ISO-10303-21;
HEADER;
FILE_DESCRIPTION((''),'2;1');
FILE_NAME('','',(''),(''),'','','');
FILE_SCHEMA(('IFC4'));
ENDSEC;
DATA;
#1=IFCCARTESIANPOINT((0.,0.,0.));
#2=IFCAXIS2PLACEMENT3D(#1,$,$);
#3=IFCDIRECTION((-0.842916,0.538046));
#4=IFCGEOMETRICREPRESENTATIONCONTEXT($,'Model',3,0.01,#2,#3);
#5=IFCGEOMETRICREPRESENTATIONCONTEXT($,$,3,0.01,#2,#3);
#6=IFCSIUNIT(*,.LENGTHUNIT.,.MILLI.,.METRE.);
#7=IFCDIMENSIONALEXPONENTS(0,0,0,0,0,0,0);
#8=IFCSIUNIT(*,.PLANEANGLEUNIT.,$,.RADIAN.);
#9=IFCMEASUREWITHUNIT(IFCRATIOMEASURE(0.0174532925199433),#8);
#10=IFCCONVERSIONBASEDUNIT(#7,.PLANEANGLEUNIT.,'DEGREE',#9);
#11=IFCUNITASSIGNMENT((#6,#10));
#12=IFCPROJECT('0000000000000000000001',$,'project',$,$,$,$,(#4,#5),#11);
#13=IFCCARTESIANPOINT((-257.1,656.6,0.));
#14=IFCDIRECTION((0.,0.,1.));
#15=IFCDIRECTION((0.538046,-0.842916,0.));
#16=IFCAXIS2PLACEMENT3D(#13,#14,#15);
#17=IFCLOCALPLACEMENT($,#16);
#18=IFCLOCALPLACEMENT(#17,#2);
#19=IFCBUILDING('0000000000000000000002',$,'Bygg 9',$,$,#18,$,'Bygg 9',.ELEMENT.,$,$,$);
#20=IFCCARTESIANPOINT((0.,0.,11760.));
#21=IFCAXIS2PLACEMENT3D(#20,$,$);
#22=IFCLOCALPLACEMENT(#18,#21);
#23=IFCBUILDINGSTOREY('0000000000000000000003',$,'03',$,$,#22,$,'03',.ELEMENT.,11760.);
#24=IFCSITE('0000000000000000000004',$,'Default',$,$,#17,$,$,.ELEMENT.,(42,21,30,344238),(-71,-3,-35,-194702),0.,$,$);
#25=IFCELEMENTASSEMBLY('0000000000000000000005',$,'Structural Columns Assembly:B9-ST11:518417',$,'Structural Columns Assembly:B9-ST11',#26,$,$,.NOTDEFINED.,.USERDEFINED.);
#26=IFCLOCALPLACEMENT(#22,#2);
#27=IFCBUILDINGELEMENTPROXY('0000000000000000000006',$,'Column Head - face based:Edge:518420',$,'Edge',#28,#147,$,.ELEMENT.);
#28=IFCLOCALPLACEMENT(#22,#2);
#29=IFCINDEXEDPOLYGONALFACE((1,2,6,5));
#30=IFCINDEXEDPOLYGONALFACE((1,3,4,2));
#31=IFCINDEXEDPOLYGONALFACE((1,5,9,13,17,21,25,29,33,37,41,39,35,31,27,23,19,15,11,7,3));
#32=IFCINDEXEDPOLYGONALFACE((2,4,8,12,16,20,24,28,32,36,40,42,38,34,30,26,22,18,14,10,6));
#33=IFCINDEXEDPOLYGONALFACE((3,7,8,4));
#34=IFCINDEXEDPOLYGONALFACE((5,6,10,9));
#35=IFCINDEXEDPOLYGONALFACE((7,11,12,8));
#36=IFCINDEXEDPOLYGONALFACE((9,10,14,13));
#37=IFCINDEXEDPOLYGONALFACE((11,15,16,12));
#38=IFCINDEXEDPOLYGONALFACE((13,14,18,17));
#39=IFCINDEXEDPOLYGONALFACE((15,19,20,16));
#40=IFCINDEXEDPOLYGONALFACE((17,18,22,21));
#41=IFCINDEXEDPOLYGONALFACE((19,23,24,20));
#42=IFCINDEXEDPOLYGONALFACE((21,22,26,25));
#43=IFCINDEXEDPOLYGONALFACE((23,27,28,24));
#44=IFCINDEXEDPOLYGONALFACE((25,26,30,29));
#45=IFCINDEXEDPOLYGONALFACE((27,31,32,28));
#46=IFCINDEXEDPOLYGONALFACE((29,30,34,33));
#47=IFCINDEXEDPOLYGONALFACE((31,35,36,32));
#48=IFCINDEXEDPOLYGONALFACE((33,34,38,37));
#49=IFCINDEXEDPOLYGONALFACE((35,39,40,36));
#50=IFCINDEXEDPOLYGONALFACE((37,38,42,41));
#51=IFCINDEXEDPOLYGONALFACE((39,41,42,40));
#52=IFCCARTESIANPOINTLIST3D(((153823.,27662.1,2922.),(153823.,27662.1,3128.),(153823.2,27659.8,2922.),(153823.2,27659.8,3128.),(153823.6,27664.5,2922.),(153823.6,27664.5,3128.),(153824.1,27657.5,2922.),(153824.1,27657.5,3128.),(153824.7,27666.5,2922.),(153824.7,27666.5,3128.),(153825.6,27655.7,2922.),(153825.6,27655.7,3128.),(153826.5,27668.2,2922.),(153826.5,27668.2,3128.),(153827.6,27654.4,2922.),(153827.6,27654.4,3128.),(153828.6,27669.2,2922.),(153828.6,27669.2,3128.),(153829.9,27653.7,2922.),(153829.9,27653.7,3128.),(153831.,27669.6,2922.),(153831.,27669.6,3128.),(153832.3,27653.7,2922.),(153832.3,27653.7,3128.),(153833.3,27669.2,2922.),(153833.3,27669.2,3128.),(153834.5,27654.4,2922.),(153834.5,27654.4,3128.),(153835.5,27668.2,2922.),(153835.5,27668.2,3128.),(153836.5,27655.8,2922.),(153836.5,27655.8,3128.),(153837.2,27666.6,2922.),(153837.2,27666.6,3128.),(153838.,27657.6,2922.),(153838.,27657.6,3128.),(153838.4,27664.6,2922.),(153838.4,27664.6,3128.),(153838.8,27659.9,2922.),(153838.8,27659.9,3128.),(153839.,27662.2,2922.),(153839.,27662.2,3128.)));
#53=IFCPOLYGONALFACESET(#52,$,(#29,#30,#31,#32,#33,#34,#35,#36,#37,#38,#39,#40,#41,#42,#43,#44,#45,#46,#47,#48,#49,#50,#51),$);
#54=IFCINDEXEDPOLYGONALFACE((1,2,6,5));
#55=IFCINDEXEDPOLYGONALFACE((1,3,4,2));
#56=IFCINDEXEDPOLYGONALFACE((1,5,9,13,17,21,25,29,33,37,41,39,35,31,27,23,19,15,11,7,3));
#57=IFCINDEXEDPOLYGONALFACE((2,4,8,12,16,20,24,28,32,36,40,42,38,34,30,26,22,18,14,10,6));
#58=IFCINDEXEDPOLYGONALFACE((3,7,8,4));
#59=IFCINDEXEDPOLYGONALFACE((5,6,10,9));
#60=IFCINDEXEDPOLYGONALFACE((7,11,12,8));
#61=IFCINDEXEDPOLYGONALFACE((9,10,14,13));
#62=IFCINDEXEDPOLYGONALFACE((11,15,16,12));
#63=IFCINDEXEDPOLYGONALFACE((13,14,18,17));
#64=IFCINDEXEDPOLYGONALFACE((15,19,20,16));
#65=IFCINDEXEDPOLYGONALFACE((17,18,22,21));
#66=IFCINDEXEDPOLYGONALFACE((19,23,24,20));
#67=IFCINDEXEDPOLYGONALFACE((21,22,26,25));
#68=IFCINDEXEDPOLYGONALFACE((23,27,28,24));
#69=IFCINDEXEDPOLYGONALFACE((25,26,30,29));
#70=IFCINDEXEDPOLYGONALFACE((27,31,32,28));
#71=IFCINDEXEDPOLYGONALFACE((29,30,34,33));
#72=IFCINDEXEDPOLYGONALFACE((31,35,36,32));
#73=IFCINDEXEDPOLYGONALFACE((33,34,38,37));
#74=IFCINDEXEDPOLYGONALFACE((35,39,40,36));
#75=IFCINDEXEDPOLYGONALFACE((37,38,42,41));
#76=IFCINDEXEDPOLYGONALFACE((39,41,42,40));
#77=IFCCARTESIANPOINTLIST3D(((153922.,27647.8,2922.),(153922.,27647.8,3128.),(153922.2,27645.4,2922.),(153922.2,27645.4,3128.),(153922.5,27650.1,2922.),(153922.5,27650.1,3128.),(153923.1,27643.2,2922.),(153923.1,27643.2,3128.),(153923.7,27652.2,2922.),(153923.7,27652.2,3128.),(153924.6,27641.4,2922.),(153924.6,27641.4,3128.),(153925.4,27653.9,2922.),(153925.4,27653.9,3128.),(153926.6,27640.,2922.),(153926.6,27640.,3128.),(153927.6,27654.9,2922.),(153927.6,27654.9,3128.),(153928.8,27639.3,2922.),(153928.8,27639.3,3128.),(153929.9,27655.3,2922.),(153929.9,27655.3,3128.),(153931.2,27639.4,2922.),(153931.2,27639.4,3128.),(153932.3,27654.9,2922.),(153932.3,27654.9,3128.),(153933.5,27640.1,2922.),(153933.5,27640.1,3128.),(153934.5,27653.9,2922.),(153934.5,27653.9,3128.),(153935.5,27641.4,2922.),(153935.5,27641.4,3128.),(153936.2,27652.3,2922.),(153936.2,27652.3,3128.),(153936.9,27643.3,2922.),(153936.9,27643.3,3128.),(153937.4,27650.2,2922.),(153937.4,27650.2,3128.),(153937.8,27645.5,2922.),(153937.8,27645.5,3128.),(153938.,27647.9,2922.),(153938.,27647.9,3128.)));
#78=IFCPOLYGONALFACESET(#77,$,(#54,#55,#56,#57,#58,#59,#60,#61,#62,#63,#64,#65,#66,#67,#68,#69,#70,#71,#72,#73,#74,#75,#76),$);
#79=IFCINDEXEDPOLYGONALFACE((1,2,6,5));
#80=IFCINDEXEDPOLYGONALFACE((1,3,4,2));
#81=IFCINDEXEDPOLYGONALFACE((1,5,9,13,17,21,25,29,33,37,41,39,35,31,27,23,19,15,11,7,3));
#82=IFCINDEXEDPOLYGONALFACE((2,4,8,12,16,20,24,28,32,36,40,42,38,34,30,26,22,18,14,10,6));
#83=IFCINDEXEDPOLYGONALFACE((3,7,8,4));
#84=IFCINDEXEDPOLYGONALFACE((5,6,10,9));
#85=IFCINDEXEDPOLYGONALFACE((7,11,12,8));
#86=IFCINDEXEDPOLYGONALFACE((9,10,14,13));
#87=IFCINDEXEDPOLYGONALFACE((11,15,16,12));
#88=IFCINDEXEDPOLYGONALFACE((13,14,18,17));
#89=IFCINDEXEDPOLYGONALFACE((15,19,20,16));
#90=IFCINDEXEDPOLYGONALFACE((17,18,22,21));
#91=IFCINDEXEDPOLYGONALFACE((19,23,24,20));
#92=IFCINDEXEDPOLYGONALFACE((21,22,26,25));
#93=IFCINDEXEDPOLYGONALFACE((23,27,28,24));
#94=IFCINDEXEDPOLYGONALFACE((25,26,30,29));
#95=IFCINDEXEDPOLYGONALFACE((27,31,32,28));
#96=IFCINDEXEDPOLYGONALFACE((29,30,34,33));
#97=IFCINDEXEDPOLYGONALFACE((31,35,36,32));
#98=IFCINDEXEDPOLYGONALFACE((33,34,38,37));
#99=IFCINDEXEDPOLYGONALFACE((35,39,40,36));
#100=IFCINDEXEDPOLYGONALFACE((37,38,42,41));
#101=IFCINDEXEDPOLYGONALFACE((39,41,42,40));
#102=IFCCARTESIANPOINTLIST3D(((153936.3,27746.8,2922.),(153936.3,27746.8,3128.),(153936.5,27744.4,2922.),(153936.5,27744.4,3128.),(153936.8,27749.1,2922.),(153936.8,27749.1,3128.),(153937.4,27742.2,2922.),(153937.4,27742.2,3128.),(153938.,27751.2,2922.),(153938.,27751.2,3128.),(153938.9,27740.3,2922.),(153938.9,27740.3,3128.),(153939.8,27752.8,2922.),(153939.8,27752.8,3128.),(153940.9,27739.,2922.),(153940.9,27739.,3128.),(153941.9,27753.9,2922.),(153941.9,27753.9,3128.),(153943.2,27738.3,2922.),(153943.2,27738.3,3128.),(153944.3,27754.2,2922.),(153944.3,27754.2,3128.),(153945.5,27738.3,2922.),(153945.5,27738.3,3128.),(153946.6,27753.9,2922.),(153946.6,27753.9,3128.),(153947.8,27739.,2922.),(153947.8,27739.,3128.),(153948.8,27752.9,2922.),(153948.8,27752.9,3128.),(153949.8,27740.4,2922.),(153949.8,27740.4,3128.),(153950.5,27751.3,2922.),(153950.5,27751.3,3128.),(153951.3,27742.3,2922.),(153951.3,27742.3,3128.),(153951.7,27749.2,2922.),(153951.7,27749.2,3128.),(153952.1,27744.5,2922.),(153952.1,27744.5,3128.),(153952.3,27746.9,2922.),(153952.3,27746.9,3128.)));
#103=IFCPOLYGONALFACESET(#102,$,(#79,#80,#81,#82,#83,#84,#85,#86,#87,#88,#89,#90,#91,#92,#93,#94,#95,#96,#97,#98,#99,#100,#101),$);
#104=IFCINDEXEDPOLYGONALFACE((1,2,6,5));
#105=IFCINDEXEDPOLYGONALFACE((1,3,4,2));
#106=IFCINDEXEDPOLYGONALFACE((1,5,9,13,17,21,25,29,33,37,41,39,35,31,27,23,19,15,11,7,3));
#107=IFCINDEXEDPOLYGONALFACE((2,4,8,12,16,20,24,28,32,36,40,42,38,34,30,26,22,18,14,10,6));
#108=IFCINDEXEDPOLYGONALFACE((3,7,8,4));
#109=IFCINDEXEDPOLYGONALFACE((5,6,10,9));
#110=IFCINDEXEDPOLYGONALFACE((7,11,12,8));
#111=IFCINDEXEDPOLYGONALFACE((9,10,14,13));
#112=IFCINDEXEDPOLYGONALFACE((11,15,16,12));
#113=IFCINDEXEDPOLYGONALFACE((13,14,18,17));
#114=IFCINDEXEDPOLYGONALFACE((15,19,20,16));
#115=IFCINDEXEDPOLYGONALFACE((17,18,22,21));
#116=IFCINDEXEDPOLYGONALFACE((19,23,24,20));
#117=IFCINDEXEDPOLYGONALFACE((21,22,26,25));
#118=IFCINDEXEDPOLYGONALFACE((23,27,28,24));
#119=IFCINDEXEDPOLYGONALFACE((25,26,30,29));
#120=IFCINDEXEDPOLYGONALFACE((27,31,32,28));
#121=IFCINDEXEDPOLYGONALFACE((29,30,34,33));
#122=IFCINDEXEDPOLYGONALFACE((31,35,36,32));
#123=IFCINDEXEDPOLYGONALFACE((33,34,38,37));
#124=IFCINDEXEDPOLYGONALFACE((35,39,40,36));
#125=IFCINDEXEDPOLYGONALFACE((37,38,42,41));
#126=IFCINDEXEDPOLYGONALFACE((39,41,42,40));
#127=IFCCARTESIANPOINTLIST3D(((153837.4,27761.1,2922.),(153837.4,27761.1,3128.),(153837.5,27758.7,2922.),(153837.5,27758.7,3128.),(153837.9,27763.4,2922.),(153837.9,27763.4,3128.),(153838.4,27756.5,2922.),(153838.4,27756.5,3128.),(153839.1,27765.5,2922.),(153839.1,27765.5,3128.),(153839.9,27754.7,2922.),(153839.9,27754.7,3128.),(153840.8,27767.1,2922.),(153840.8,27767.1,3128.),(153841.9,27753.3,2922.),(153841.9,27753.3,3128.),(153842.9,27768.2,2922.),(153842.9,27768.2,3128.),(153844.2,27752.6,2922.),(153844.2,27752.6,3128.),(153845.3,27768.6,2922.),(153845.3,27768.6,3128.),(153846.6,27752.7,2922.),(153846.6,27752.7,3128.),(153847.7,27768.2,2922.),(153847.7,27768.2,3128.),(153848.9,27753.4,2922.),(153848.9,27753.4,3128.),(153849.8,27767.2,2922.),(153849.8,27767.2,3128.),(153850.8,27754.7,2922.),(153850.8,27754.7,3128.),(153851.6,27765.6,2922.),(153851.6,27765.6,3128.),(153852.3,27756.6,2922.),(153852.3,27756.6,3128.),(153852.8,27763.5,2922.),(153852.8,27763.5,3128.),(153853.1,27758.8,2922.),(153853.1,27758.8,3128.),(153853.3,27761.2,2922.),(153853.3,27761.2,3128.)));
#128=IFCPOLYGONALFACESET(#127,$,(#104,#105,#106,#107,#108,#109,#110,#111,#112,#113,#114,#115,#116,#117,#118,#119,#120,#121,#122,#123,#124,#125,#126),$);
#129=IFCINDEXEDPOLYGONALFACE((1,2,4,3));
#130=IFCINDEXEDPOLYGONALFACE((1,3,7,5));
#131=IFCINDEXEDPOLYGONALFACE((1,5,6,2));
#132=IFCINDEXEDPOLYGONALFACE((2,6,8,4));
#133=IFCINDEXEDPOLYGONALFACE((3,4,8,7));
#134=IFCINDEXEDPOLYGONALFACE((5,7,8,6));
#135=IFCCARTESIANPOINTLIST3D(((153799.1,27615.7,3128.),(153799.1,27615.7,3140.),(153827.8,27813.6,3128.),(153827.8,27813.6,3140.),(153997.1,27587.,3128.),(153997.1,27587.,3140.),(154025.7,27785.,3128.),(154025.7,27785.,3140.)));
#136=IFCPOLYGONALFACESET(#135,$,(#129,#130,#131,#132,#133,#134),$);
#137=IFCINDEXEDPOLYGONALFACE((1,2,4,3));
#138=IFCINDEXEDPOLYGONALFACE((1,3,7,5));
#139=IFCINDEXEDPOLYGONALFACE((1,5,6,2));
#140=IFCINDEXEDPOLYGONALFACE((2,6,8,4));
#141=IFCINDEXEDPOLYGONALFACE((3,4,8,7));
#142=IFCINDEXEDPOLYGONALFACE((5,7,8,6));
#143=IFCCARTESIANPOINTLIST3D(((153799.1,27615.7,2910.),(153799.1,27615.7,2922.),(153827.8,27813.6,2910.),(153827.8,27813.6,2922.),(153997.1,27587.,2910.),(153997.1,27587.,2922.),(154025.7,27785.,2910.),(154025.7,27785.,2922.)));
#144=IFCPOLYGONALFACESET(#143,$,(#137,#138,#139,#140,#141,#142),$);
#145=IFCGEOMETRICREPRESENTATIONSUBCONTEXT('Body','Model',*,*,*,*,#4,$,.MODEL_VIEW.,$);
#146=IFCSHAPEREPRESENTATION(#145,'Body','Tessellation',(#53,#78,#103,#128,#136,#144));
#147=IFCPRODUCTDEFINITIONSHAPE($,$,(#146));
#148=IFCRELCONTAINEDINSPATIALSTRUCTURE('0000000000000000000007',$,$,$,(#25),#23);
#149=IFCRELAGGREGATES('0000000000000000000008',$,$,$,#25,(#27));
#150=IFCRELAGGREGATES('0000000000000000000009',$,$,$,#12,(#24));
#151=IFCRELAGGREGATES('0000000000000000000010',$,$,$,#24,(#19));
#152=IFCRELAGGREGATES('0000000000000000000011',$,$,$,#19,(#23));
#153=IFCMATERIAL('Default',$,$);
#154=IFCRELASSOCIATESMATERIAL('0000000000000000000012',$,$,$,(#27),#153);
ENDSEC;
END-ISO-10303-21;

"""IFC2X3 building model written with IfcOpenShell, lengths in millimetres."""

from ifc_helpers import new_model, entity, si_unit, converted_unit, direction, frame, frame_2d, origin, origin_2d_with_axis, place, context, subcontext, project, spatial, rectangle, circle, extrude, source, transform, mapped, material, element, aggregate, save


model = new_model("IFC2X3")

# Units and contexts
model_context = context("Model", 3, precision=0.01, world=origin(), true_north=direction((-0.842916, 0.538046)))
context_of_model = context(None, 3, precision=0.01, world=origin(), true_north=direction((-0.842916, 0.538046)))
body_context = subcontext(model_context, "Body", "Model", "MODEL_VIEW")
ifc_project = project(units=[si_unit("LENGTHUNIT", "METRE", prefix="MILLI"), converted_unit("PLANEANGLEUNIT", "DEGREE", entity("IfcRatioMeasure", 0.0174532925199433), si_unit("PLANEANGLEUNIT", "RADIAN"), dimensions=[0, 0, 0, 0, 0, 0, 0])], contexts=[model_context, context_of_model])

# Site, building, storey
site_placement = place(None, frame((-257.1, 656.6, 0.0), z_axis=(0.0, 0.0, 1.0), x_axis=(0.538046, -0.842916, 0.0)))
site = spatial("IfcSite", under=ifc_project, at=site_placement, Name="Default", CompositionType="ELEMENT", RefLatitude=(42, 21, 30, 344238), RefLongitude=(-71, -3, -35, -194702), RefElevation=0.0)
building_placement = place(site_placement, origin())
building = spatial("IfcBuilding", under=site, at=building_placement, Name="Bygg 9", LongName="Bygg 9", CompositionType="ELEMENT")
storey_placement = place(building_placement, frame((0.0, 0.0, 11760.0)))
storey = spatial("IfcBuildingStorey", under=building, at=storey_placement, Name="03", LongName="03", CompositionType="ELEMENT", Elevation=11760.0)

# Element assembly
assembly_1_placement = place(storey_placement, origin())
assembly_1 = element("IfcElementAssembly", 1, at=assembly_1_placement, inside=storey, Name="Structural Columns Assembly:B9-ST11:518417", ObjectType="Structural Columns Assembly:B9-ST11", AssemblyPlace="NOTDEFINED", PredefinedType="USERDEFINED")

# Building element proxy
ifc_material_1 = material(Name="Default")
shared_shape_1 = source(origin(), body_context, "Body", "SweptSolid", [
    extrude(circle(Radius=8.0, at=frame_2d((0.0, 0.0), x_axis=(1.0, 0.0))), frame((50.0, -75.0, 12.0)), (0.0, 0.0, 1.0), 206.0),
    extrude(circle(Radius=8.0, at=frame_2d((0.0, 0.0), x_axis=(1.0, 0.0))), frame((50.0, 25.0, 12.0)), (0.0, 0.0, 1.0), 206.0),
    extrude(circle(Radius=8.0, at=frame_2d((0.0, 0.0), x_axis=(1.0, 0.0))), frame((-50.0, 25.0, 12.0)), (0.0, 0.0, 1.0), 206.0),
    extrude(circle(Radius=8.0, at=frame_2d((0.0, 0.0), x_axis=(1.0, 0.0))), frame((-50.0, -75.0, 12.0)), (0.0, 0.0, 1.0), 206.0),
    extrude(rectangle(XDim=200.0, YDim=200.0, at=origin_2d_with_axis()), frame((0.0, 0.0, 218.0), z_axis=(0.0, 0.0, 1.0), x_axis=(-1.0, 0.0, 0.0)), (0.0, 0.0, 1.0), 12.0),
    extrude(rectangle(XDim=200.0, YDim=200.0, at=origin_2d_with_axis()), frame((0.0, 0.0, 0.0), z_axis=(0.0, 0.0, 1.0), x_axis=(0.0, 1.0, 0.0)), (0.0, 0.0, 1.0), 12.0),
])
proxy_1_placement = place(assembly_1_placement, frame((153912.4, 27700.3, 2910.0), z_axis=(0.0, 0.0, 1.0), x_axis=(-0.143216, -0.989691, 0.0)))
proxy_1 = element("IfcBuildingElementProxy", 2, at=proxy_1_placement, material=ifc_material_1, Name="Column Head - face based:Edge:518420", ObjectType="Edge", CompositionType="ELEMENT", context=body_context, shape_type="MappedRepresentation", body=[
    mapped(shared_shape_1, transform((0.0, 0.0, 0.0), scale=1.0)),
])
aggregate(assembly_1, [proxy_1])

save(model, "model.ifc")
